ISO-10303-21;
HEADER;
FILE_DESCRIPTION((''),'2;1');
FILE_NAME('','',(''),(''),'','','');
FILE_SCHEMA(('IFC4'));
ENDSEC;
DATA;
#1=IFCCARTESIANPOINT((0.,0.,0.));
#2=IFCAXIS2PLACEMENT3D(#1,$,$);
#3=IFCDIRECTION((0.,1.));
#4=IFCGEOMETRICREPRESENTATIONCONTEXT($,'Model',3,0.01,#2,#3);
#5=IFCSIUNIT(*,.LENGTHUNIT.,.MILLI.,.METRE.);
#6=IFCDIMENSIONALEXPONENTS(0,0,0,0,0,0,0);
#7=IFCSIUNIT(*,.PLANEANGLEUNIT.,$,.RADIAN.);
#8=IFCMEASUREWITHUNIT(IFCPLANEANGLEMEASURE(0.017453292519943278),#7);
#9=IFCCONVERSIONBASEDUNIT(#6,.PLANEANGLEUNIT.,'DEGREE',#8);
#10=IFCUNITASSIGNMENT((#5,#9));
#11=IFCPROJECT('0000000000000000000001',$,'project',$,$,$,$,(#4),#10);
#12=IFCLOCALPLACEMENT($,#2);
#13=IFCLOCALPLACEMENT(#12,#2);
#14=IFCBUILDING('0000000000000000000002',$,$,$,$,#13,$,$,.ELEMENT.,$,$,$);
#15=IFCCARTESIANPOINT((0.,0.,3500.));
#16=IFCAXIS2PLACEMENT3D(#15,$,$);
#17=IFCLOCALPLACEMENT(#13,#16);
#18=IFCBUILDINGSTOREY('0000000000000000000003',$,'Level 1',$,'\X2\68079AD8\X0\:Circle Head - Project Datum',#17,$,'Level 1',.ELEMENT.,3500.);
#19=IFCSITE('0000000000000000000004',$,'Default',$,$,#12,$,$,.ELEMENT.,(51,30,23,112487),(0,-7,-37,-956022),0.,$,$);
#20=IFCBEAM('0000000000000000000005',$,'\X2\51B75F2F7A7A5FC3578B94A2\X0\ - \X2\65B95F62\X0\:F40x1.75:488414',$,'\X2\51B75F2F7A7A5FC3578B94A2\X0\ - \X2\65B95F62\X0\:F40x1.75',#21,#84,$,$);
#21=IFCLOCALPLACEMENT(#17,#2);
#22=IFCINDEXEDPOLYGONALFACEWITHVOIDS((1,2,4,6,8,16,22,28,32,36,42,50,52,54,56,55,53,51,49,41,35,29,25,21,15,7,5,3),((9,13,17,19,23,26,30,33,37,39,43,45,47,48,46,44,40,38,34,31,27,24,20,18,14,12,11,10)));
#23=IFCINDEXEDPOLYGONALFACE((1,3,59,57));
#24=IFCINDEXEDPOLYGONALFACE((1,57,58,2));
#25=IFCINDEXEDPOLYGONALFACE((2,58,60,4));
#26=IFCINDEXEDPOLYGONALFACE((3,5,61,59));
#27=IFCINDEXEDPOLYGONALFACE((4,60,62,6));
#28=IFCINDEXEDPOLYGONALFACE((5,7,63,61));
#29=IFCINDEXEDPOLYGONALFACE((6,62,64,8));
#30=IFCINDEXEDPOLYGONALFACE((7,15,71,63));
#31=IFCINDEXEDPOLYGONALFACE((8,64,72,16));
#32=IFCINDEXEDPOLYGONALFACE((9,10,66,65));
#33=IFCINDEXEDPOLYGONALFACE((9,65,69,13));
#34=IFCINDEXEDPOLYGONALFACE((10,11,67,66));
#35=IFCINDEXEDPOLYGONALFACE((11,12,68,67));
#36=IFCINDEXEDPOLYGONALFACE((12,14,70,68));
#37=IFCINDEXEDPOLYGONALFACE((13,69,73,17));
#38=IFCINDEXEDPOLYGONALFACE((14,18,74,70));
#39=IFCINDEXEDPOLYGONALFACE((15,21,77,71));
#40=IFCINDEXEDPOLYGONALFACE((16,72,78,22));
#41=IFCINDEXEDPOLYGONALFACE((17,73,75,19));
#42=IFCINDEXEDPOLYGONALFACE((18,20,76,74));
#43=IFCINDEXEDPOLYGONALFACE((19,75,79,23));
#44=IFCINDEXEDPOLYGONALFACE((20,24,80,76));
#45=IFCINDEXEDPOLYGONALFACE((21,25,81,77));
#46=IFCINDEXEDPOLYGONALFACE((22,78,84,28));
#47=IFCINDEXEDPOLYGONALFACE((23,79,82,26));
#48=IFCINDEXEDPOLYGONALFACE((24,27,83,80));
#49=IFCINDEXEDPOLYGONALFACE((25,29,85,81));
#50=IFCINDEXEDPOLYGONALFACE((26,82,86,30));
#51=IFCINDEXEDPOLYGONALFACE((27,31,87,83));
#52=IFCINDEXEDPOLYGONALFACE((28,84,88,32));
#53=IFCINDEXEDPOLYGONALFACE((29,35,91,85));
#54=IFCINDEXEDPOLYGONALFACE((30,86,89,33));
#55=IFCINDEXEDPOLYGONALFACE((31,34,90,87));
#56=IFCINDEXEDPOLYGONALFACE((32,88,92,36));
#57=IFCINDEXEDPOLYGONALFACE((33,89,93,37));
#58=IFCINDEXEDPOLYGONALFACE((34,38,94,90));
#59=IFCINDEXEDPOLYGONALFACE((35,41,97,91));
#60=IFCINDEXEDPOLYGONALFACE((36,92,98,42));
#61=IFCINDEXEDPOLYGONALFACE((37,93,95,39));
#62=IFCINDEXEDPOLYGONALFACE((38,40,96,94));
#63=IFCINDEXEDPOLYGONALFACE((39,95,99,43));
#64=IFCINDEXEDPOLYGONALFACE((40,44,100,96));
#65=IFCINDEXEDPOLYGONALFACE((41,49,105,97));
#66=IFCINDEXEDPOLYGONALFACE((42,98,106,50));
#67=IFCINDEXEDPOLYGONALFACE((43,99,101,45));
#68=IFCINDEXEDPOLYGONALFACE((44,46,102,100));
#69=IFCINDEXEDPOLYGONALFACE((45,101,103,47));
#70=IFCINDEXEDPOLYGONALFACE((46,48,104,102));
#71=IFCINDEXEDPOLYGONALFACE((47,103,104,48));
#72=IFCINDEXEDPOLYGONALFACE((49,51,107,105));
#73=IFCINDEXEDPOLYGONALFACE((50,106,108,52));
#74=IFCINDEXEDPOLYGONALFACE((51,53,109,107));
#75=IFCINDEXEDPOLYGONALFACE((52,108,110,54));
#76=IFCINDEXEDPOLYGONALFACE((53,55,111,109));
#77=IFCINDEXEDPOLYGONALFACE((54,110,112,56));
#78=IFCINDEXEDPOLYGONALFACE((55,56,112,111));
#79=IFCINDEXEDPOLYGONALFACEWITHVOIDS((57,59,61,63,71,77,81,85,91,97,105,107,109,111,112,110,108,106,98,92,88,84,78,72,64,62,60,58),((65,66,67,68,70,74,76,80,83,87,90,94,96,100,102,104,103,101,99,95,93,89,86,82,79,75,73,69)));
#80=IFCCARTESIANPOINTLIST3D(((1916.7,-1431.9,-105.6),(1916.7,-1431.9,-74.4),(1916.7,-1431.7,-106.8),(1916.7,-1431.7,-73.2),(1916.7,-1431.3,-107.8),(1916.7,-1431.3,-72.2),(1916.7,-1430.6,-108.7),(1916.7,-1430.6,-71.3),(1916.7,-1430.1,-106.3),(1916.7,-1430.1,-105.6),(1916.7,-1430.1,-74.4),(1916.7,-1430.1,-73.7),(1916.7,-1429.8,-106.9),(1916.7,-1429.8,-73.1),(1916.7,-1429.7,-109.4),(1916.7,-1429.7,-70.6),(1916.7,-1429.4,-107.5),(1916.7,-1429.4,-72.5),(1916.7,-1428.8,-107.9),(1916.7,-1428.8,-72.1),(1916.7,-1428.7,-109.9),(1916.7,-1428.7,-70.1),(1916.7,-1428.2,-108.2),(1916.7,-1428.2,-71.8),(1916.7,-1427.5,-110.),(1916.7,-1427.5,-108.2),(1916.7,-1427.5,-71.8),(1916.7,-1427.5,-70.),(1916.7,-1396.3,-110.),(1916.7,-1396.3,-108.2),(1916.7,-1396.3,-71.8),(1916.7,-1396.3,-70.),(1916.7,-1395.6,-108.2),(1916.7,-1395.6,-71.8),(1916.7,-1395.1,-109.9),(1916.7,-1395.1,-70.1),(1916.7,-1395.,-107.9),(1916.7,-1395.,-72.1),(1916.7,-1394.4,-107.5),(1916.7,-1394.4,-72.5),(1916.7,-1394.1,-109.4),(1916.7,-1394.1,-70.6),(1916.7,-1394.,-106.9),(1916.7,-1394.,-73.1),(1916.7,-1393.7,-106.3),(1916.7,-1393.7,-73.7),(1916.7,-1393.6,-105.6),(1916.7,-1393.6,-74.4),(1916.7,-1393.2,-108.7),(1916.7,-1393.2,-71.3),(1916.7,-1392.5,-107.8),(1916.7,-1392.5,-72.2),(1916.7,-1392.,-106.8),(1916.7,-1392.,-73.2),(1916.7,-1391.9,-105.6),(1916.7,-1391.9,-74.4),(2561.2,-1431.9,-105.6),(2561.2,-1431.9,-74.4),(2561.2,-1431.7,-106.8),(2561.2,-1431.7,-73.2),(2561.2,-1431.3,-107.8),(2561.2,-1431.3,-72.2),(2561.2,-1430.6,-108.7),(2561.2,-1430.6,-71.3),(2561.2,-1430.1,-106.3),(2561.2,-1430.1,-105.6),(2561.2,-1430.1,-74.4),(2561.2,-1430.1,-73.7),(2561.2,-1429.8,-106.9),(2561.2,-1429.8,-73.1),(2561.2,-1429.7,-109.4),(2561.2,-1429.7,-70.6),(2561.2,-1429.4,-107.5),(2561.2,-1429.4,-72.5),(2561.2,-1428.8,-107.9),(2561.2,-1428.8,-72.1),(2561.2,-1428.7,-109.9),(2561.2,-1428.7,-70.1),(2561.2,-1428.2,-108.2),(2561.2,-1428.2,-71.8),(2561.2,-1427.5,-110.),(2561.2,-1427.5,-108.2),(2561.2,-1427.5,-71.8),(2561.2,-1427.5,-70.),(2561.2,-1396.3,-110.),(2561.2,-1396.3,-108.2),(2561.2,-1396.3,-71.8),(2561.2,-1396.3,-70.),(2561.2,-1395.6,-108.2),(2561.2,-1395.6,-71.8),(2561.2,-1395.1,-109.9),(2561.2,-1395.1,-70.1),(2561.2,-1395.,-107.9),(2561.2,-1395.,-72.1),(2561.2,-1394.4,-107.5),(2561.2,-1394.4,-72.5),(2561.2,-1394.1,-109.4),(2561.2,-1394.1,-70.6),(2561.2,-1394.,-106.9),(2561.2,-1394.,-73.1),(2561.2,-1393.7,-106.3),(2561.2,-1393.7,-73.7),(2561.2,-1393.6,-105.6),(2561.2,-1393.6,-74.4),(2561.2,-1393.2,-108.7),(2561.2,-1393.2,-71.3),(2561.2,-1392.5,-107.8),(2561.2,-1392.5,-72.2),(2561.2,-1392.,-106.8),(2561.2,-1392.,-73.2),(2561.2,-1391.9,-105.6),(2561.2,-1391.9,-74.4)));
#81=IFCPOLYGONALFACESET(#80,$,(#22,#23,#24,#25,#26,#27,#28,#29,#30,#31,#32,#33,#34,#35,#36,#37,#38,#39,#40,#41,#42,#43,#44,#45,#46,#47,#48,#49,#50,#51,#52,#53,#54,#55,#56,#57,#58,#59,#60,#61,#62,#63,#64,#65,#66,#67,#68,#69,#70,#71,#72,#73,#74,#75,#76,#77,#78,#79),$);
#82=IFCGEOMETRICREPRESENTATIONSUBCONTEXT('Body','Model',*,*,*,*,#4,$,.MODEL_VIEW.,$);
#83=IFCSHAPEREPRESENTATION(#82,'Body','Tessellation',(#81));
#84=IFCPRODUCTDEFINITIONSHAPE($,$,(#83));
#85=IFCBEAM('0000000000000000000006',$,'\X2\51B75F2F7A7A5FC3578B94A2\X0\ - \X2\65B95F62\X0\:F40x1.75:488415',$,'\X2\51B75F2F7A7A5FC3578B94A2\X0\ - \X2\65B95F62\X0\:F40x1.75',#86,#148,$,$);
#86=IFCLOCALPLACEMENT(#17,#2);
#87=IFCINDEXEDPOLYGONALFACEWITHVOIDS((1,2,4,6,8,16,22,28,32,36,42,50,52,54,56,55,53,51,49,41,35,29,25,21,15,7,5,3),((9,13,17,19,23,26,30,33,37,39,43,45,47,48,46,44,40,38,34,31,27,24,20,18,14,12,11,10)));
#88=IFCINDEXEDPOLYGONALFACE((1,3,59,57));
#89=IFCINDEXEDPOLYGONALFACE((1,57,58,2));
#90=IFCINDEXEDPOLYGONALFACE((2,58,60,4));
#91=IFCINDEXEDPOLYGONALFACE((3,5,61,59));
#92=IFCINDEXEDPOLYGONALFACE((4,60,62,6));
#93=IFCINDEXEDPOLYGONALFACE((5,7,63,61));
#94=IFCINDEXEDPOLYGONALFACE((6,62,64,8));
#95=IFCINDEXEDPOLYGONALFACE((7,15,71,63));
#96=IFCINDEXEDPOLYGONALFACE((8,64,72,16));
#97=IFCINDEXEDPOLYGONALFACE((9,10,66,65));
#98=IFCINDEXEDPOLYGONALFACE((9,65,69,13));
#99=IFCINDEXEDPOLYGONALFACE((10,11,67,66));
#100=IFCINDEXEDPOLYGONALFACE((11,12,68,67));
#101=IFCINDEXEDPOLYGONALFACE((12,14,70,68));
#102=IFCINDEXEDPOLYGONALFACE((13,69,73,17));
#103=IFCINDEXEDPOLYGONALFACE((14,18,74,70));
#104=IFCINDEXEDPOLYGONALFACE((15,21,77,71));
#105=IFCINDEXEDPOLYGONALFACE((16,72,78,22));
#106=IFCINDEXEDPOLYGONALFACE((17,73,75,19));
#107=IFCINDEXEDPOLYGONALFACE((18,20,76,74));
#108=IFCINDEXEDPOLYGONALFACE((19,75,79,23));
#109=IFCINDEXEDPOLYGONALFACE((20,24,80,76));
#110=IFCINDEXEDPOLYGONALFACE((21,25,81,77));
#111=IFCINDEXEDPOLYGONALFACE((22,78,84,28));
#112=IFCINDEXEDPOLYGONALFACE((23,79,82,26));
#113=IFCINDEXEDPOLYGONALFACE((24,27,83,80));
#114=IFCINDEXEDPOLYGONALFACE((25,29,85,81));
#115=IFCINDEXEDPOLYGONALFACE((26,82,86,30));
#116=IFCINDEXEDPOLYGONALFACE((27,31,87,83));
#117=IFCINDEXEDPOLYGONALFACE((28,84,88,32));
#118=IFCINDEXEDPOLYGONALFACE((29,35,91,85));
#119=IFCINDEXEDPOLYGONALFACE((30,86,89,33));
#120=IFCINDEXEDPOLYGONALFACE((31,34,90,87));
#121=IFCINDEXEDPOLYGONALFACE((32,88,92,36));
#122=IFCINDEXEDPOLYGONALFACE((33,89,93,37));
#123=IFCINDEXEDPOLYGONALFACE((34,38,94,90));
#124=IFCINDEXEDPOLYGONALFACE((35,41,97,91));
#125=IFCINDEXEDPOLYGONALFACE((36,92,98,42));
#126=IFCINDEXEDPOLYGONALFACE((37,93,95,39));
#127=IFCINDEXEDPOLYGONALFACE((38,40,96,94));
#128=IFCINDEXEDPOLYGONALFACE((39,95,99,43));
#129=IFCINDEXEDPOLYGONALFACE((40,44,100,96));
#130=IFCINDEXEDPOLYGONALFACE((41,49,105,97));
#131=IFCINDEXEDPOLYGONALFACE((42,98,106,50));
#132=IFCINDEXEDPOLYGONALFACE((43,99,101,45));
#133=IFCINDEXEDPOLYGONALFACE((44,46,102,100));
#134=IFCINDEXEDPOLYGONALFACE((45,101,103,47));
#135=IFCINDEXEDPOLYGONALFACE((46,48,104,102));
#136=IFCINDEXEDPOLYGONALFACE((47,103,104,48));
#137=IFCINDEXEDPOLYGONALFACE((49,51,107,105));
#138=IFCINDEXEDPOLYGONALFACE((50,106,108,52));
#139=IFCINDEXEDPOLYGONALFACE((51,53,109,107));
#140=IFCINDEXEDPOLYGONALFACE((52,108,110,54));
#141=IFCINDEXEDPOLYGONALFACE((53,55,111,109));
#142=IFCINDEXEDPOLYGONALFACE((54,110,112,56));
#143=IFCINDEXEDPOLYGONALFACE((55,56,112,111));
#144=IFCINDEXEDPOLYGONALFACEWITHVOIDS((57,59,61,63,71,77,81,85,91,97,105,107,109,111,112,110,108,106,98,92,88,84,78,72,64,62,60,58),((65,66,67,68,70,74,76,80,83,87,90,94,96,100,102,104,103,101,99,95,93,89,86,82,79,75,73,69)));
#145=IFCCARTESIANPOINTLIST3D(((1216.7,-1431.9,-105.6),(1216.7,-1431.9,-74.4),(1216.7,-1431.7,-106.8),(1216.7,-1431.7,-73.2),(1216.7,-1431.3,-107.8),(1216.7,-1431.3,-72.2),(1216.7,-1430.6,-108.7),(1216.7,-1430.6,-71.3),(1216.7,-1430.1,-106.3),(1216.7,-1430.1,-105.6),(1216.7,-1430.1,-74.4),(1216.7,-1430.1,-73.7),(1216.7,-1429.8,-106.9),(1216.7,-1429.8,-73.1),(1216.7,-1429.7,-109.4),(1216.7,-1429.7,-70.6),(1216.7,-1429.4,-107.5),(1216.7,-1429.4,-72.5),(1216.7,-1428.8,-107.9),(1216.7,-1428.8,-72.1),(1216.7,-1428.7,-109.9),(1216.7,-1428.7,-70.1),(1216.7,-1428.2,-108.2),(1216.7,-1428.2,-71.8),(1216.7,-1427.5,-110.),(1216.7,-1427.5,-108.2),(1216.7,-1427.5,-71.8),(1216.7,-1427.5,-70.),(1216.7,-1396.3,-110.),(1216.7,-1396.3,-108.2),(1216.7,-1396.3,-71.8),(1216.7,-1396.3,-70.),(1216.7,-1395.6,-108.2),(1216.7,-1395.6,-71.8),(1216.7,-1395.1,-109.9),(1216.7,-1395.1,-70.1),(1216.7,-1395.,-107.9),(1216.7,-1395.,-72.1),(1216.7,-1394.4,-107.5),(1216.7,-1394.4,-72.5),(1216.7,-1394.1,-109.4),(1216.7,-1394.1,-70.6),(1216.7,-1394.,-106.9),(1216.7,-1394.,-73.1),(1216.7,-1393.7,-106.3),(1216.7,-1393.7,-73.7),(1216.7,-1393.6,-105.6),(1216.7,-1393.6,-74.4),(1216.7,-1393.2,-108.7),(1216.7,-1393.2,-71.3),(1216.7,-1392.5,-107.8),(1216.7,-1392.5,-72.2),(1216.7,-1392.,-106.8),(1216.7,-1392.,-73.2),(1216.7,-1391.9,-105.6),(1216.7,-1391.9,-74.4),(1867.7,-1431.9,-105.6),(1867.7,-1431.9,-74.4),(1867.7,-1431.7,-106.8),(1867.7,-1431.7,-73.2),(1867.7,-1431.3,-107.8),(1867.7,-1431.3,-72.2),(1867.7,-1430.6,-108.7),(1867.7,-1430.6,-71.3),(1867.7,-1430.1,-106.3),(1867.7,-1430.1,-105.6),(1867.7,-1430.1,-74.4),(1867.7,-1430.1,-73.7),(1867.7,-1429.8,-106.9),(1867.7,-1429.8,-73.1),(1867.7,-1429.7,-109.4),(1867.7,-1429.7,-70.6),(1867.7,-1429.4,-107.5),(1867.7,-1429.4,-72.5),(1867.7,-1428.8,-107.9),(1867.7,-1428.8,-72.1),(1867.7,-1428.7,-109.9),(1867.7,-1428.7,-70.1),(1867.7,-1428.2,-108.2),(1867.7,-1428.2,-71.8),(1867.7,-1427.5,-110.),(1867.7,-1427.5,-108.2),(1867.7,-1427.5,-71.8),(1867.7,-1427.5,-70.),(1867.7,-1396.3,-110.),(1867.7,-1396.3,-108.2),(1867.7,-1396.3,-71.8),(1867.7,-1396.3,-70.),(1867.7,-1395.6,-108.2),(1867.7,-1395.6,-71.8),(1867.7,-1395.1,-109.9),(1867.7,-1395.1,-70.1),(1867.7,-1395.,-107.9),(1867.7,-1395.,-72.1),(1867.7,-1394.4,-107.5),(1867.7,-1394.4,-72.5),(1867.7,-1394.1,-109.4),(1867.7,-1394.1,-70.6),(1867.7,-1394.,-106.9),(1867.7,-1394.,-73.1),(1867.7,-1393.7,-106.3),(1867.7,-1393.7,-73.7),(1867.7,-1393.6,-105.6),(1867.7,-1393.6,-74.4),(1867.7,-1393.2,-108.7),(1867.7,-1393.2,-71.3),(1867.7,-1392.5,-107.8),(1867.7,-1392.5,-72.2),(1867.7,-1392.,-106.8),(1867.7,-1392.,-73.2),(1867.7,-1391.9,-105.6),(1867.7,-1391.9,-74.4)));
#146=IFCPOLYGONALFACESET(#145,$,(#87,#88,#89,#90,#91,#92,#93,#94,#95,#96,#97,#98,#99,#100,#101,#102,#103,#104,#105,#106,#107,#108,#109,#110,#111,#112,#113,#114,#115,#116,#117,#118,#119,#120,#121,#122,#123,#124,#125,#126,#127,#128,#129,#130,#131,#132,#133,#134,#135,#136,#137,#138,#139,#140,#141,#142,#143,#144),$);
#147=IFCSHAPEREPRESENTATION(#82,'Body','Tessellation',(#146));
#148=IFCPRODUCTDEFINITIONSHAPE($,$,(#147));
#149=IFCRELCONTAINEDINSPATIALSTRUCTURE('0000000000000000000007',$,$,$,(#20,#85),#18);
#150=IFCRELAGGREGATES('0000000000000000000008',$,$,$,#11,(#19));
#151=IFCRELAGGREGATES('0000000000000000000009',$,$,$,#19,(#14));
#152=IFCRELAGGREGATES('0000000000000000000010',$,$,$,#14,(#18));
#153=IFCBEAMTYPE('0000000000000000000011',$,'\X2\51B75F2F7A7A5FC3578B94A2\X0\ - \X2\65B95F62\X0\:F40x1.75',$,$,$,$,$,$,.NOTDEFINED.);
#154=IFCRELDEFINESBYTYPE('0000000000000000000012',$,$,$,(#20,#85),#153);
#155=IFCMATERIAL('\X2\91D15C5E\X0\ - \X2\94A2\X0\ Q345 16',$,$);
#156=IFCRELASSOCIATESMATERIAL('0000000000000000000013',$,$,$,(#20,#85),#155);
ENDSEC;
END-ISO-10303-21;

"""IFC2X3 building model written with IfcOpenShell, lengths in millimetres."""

from ifc_helpers import new_model, entity, si_unit, converted_unit, direction, frame, frame_2d, origin, place, context, subcontext, project, spatial, polyline, circle_curve, parameter, trimmed, segment, composite_curve, outline, extrude, material, type_object, element, save


model = new_model("IFC2X3")

# Units and contexts
model_context = context("Model", 3, precision=0.01, world=origin(), true_north=direction((0.0, 1.0)))
body_context = subcontext(model_context, "Body", "Model", "MODEL_VIEW")
ifc_project = project(units=[si_unit("LENGTHUNIT", "METRE", prefix="MILLI"), converted_unit("PLANEANGLEUNIT", "DEGREE", entity("IfcPlaneAngleMeasure", 0.017453292519943278), si_unit("PLANEANGLEUNIT", "RADIAN"), dimensions=[0, 0, 0, 0, 0, 0, 0])], contexts=[model_context])

# Site, building, storey
site_placement = place(None, origin())
site = spatial("IfcSite", under=ifc_project, at=site_placement, Name="Default", CompositionType="ELEMENT", RefLatitude=(51, 30, 23, 112487), RefLongitude=(0, -7, -37, -956022), RefElevation=0.0)
building_placement = place(site_placement, origin())
building = spatial("IfcBuilding", under=site, at=building_placement, CompositionType="ELEMENT")
storey_placement = place(building_placement, frame((0.0, 0.0, 3500.0)))
storey = spatial("IfcBuildingStorey", under=building, at=storey_placement, Name="Level 1", ObjectType="标高:Circle Head - Project Datum", LongName="Level 1", CompositionType="ELEMENT", Elevation=3500.0)

# Beams
ifc_material_1 = material(Name="金属 - 钢 Q345 16")
beam_type_1 = type_object("IfcBeamType", Name="冷弯空心型钢 - 方形:F40x1.75", PredefinedType="NOTDEFINED")
beam_1_placement = place(storey_placement, frame((1868.7, -1411.9, -70.0)))
element("IfcBeam", 1, at=beam_1_placement, inside=storey, type_object=beam_type_1, material=ifc_material_1, Name="冷弯空心型钢 - 方形:F40x1.75:488414", ObjectType="冷弯空心型钢 - 方形:F40x1.75", context=body_context, shape_type="SweptSolid", body=[
    extrude(outline(composite_curve([segment(trimmed(circle_curve(frame_2d((-15.6, 15.6), x_axis=(1.0, 0.0)), 4.4), [parameter(90.0)], [parameter(180.0)], True, "PARAMETER"), True, "CONTINUOUS"), segment(polyline([(-20.0, 15.6), (-20.0, -15.6)]), True, "CONTINUOUS"), segment(trimmed(circle_curve(frame_2d((-15.6, -15.6), x_axis=(1.0, 0.0)), 4.4), [parameter(180.0)], [parameter(270.0)], True, "PARAMETER"), True, "CONTINUOUS"), segment(polyline([(-15.6, -20.0), (15.6, -20.0)]), True, "CONTINUOUS"), segment(trimmed(circle_curve(frame_2d((15.6, -15.6), x_axis=(1.0, 0.0)), 4.4), [parameter(270.0)], [parameter(0.0)], True, "PARAMETER"), True, "CONTINUOUS"), segment(polyline([(20.0, -15.6), (20.0, 15.6)]), True, "CONTINUOUS"), segment(trimmed(circle_curve(frame_2d((15.6, 15.6), x_axis=(1.0, 0.0)), 4.4), [parameter(0.0)], [parameter(90.0)], True, "PARAMETER"), True, "CONTINUOUS"), segment(polyline([(15.6, 20.0), (-15.6, 20.0)]), True, "CONTINUOUS")], self_intersect=False), holes=[composite_curve([segment(polyline([(-15.6, 18.3), (15.6, 18.3)]), True, "CONTINUOUS"), segment(trimmed(circle_curve(frame_2d((15.6, 15.6), x_axis=(1.0, 0.0)), 2.6), [parameter(0.0)], [parameter(90.0)], True, "PARAMETER"), False, "CONTINUOUS"), segment(polyline([(18.2, 15.6), (18.2, -15.6)]), True, "CONTINUOUS"), segment(trimmed(circle_curve(frame_2d((15.6, -15.6), x_axis=(1.0, 0.0)), 2.6), [parameter(270.0)], [parameter(360.0)], True, "PARAMETER"), False, "CONTINUOUS"), segment(polyline([(15.6, -18.3), (-15.6, -18.3)]), True, "CONTINUOUS"), segment(trimmed(circle_curve(frame_2d((-15.6, -15.6), x_axis=(1.0, 0.0)), 2.6), [parameter(180.0)], [parameter(270.0)], True, "PARAMETER"), False, "CONTINUOUS"), segment(polyline([(-18.3, -15.6), (-18.3, 15.6)]), True, "CONTINUOUS"), segment(trimmed(circle_curve(frame_2d((-15.6, 15.6), x_axis=(1.0, 0.0)), 2.6), [parameter(90.0)], [parameter(180.0)], True, "PARAMETER"), False, "CONTINUOUS")], self_intersect=False)]), frame((48.0, 0.0, -20.0), z_axis=(1.0, 0.0, 0.0), x_axis=(0.0, 1.0, 0.0)), (0.0, 0.0, 1.0), 644.5),
])
beam_2_placement = place(storey_placement, frame((1168.7, -1411.9, -70.0)))
element("IfcBeam", 2, at=beam_2_placement, inside=storey, type_object=beam_type_1, material=ifc_material_1, Name="冷弯空心型钢 - 方形:F40x1.75:488415", ObjectType="冷弯空心型钢 - 方形:F40x1.75", context=body_context, shape_type="SweptSolid", body=[
    extrude(outline(composite_curve([segment(trimmed(circle_curve(frame_2d((-15.6, 15.6), x_axis=(1.0, 0.0)), 4.4), [parameter(90.0)], [parameter(180.0)], True, "PARAMETER"), True, "CONTINUOUS"), segment(polyline([(-20.0, 15.6), (-20.0, -15.6)]), True, "CONTINUOUS"), segment(trimmed(circle_curve(frame_2d((-15.6, -15.6), x_axis=(1.0, 0.0)), 4.4), [parameter(180.0)], [parameter(270.0)], True, "PARAMETER"), True, "CONTINUOUS"), segment(polyline([(-15.6, -20.0), (15.6, -20.0)]), True, "CONTINUOUS"), segment(trimmed(circle_curve(frame_2d((15.6, -15.6), x_axis=(1.0, 0.0)), 4.4), [parameter(270.0)], [parameter(0.0)], True, "PARAMETER"), True, "CONTINUOUS"), segment(polyline([(20.0, -15.6), (20.0, 15.6)]), True, "CONTINUOUS"), segment(trimmed(circle_curve(frame_2d((15.6, 15.6), x_axis=(1.0, 0.0)), 4.4), [parameter(0.0)], [parameter(90.0)], True, "PARAMETER"), True, "CONTINUOUS"), segment(polyline([(15.6, 20.0), (-15.6, 20.0)]), True, "CONTINUOUS")], self_intersect=False), holes=[composite_curve([segment(polyline([(-15.6, 18.3), (15.6, 18.3)]), True, "CONTINUOUS"), segment(trimmed(circle_curve(frame_2d((15.6, 15.6), x_axis=(1.0, 0.0)), 2.6), [parameter(0.0)], [parameter(90.0)], True, "PARAMETER"), False, "CONTINUOUS"), segment(polyline([(18.2, 15.6), (18.2, -15.6)]), True, "CONTINUOUS"), segment(trimmed(circle_curve(frame_2d((15.6, -15.6), x_axis=(1.0, 0.0)), 2.6), [parameter(270.0)], [parameter(360.0)], True, "PARAMETER"), False, "CONTINUOUS"), segment(polyline([(15.6, -18.3), (-15.6, -18.3)]), True, "CONTINUOUS"), segment(trimmed(circle_curve(frame_2d((-15.6, -15.6), x_axis=(1.0, 0.0)), 2.6), [parameter(180.0)], [parameter(270.0)], True, "PARAMETER"), False, "CONTINUOUS"), segment(polyline([(-18.3, -15.6), (-18.3, 15.6)]), True, "CONTINUOUS"), segment(trimmed(circle_curve(frame_2d((-15.6, 15.6), x_axis=(1.0, 0.0)), 2.6), [parameter(90.0)], [parameter(180.0)], True, "PARAMETER"), False, "CONTINUOUS")], self_intersect=False)]), frame((48.0, 0.0, -20.0), z_axis=(1.0, 0.0, 0.0), x_axis=(0.0, 1.0, 0.0)), (0.0, 0.0, 1.0), 651.0),
])

save(model, "model.ifc")
